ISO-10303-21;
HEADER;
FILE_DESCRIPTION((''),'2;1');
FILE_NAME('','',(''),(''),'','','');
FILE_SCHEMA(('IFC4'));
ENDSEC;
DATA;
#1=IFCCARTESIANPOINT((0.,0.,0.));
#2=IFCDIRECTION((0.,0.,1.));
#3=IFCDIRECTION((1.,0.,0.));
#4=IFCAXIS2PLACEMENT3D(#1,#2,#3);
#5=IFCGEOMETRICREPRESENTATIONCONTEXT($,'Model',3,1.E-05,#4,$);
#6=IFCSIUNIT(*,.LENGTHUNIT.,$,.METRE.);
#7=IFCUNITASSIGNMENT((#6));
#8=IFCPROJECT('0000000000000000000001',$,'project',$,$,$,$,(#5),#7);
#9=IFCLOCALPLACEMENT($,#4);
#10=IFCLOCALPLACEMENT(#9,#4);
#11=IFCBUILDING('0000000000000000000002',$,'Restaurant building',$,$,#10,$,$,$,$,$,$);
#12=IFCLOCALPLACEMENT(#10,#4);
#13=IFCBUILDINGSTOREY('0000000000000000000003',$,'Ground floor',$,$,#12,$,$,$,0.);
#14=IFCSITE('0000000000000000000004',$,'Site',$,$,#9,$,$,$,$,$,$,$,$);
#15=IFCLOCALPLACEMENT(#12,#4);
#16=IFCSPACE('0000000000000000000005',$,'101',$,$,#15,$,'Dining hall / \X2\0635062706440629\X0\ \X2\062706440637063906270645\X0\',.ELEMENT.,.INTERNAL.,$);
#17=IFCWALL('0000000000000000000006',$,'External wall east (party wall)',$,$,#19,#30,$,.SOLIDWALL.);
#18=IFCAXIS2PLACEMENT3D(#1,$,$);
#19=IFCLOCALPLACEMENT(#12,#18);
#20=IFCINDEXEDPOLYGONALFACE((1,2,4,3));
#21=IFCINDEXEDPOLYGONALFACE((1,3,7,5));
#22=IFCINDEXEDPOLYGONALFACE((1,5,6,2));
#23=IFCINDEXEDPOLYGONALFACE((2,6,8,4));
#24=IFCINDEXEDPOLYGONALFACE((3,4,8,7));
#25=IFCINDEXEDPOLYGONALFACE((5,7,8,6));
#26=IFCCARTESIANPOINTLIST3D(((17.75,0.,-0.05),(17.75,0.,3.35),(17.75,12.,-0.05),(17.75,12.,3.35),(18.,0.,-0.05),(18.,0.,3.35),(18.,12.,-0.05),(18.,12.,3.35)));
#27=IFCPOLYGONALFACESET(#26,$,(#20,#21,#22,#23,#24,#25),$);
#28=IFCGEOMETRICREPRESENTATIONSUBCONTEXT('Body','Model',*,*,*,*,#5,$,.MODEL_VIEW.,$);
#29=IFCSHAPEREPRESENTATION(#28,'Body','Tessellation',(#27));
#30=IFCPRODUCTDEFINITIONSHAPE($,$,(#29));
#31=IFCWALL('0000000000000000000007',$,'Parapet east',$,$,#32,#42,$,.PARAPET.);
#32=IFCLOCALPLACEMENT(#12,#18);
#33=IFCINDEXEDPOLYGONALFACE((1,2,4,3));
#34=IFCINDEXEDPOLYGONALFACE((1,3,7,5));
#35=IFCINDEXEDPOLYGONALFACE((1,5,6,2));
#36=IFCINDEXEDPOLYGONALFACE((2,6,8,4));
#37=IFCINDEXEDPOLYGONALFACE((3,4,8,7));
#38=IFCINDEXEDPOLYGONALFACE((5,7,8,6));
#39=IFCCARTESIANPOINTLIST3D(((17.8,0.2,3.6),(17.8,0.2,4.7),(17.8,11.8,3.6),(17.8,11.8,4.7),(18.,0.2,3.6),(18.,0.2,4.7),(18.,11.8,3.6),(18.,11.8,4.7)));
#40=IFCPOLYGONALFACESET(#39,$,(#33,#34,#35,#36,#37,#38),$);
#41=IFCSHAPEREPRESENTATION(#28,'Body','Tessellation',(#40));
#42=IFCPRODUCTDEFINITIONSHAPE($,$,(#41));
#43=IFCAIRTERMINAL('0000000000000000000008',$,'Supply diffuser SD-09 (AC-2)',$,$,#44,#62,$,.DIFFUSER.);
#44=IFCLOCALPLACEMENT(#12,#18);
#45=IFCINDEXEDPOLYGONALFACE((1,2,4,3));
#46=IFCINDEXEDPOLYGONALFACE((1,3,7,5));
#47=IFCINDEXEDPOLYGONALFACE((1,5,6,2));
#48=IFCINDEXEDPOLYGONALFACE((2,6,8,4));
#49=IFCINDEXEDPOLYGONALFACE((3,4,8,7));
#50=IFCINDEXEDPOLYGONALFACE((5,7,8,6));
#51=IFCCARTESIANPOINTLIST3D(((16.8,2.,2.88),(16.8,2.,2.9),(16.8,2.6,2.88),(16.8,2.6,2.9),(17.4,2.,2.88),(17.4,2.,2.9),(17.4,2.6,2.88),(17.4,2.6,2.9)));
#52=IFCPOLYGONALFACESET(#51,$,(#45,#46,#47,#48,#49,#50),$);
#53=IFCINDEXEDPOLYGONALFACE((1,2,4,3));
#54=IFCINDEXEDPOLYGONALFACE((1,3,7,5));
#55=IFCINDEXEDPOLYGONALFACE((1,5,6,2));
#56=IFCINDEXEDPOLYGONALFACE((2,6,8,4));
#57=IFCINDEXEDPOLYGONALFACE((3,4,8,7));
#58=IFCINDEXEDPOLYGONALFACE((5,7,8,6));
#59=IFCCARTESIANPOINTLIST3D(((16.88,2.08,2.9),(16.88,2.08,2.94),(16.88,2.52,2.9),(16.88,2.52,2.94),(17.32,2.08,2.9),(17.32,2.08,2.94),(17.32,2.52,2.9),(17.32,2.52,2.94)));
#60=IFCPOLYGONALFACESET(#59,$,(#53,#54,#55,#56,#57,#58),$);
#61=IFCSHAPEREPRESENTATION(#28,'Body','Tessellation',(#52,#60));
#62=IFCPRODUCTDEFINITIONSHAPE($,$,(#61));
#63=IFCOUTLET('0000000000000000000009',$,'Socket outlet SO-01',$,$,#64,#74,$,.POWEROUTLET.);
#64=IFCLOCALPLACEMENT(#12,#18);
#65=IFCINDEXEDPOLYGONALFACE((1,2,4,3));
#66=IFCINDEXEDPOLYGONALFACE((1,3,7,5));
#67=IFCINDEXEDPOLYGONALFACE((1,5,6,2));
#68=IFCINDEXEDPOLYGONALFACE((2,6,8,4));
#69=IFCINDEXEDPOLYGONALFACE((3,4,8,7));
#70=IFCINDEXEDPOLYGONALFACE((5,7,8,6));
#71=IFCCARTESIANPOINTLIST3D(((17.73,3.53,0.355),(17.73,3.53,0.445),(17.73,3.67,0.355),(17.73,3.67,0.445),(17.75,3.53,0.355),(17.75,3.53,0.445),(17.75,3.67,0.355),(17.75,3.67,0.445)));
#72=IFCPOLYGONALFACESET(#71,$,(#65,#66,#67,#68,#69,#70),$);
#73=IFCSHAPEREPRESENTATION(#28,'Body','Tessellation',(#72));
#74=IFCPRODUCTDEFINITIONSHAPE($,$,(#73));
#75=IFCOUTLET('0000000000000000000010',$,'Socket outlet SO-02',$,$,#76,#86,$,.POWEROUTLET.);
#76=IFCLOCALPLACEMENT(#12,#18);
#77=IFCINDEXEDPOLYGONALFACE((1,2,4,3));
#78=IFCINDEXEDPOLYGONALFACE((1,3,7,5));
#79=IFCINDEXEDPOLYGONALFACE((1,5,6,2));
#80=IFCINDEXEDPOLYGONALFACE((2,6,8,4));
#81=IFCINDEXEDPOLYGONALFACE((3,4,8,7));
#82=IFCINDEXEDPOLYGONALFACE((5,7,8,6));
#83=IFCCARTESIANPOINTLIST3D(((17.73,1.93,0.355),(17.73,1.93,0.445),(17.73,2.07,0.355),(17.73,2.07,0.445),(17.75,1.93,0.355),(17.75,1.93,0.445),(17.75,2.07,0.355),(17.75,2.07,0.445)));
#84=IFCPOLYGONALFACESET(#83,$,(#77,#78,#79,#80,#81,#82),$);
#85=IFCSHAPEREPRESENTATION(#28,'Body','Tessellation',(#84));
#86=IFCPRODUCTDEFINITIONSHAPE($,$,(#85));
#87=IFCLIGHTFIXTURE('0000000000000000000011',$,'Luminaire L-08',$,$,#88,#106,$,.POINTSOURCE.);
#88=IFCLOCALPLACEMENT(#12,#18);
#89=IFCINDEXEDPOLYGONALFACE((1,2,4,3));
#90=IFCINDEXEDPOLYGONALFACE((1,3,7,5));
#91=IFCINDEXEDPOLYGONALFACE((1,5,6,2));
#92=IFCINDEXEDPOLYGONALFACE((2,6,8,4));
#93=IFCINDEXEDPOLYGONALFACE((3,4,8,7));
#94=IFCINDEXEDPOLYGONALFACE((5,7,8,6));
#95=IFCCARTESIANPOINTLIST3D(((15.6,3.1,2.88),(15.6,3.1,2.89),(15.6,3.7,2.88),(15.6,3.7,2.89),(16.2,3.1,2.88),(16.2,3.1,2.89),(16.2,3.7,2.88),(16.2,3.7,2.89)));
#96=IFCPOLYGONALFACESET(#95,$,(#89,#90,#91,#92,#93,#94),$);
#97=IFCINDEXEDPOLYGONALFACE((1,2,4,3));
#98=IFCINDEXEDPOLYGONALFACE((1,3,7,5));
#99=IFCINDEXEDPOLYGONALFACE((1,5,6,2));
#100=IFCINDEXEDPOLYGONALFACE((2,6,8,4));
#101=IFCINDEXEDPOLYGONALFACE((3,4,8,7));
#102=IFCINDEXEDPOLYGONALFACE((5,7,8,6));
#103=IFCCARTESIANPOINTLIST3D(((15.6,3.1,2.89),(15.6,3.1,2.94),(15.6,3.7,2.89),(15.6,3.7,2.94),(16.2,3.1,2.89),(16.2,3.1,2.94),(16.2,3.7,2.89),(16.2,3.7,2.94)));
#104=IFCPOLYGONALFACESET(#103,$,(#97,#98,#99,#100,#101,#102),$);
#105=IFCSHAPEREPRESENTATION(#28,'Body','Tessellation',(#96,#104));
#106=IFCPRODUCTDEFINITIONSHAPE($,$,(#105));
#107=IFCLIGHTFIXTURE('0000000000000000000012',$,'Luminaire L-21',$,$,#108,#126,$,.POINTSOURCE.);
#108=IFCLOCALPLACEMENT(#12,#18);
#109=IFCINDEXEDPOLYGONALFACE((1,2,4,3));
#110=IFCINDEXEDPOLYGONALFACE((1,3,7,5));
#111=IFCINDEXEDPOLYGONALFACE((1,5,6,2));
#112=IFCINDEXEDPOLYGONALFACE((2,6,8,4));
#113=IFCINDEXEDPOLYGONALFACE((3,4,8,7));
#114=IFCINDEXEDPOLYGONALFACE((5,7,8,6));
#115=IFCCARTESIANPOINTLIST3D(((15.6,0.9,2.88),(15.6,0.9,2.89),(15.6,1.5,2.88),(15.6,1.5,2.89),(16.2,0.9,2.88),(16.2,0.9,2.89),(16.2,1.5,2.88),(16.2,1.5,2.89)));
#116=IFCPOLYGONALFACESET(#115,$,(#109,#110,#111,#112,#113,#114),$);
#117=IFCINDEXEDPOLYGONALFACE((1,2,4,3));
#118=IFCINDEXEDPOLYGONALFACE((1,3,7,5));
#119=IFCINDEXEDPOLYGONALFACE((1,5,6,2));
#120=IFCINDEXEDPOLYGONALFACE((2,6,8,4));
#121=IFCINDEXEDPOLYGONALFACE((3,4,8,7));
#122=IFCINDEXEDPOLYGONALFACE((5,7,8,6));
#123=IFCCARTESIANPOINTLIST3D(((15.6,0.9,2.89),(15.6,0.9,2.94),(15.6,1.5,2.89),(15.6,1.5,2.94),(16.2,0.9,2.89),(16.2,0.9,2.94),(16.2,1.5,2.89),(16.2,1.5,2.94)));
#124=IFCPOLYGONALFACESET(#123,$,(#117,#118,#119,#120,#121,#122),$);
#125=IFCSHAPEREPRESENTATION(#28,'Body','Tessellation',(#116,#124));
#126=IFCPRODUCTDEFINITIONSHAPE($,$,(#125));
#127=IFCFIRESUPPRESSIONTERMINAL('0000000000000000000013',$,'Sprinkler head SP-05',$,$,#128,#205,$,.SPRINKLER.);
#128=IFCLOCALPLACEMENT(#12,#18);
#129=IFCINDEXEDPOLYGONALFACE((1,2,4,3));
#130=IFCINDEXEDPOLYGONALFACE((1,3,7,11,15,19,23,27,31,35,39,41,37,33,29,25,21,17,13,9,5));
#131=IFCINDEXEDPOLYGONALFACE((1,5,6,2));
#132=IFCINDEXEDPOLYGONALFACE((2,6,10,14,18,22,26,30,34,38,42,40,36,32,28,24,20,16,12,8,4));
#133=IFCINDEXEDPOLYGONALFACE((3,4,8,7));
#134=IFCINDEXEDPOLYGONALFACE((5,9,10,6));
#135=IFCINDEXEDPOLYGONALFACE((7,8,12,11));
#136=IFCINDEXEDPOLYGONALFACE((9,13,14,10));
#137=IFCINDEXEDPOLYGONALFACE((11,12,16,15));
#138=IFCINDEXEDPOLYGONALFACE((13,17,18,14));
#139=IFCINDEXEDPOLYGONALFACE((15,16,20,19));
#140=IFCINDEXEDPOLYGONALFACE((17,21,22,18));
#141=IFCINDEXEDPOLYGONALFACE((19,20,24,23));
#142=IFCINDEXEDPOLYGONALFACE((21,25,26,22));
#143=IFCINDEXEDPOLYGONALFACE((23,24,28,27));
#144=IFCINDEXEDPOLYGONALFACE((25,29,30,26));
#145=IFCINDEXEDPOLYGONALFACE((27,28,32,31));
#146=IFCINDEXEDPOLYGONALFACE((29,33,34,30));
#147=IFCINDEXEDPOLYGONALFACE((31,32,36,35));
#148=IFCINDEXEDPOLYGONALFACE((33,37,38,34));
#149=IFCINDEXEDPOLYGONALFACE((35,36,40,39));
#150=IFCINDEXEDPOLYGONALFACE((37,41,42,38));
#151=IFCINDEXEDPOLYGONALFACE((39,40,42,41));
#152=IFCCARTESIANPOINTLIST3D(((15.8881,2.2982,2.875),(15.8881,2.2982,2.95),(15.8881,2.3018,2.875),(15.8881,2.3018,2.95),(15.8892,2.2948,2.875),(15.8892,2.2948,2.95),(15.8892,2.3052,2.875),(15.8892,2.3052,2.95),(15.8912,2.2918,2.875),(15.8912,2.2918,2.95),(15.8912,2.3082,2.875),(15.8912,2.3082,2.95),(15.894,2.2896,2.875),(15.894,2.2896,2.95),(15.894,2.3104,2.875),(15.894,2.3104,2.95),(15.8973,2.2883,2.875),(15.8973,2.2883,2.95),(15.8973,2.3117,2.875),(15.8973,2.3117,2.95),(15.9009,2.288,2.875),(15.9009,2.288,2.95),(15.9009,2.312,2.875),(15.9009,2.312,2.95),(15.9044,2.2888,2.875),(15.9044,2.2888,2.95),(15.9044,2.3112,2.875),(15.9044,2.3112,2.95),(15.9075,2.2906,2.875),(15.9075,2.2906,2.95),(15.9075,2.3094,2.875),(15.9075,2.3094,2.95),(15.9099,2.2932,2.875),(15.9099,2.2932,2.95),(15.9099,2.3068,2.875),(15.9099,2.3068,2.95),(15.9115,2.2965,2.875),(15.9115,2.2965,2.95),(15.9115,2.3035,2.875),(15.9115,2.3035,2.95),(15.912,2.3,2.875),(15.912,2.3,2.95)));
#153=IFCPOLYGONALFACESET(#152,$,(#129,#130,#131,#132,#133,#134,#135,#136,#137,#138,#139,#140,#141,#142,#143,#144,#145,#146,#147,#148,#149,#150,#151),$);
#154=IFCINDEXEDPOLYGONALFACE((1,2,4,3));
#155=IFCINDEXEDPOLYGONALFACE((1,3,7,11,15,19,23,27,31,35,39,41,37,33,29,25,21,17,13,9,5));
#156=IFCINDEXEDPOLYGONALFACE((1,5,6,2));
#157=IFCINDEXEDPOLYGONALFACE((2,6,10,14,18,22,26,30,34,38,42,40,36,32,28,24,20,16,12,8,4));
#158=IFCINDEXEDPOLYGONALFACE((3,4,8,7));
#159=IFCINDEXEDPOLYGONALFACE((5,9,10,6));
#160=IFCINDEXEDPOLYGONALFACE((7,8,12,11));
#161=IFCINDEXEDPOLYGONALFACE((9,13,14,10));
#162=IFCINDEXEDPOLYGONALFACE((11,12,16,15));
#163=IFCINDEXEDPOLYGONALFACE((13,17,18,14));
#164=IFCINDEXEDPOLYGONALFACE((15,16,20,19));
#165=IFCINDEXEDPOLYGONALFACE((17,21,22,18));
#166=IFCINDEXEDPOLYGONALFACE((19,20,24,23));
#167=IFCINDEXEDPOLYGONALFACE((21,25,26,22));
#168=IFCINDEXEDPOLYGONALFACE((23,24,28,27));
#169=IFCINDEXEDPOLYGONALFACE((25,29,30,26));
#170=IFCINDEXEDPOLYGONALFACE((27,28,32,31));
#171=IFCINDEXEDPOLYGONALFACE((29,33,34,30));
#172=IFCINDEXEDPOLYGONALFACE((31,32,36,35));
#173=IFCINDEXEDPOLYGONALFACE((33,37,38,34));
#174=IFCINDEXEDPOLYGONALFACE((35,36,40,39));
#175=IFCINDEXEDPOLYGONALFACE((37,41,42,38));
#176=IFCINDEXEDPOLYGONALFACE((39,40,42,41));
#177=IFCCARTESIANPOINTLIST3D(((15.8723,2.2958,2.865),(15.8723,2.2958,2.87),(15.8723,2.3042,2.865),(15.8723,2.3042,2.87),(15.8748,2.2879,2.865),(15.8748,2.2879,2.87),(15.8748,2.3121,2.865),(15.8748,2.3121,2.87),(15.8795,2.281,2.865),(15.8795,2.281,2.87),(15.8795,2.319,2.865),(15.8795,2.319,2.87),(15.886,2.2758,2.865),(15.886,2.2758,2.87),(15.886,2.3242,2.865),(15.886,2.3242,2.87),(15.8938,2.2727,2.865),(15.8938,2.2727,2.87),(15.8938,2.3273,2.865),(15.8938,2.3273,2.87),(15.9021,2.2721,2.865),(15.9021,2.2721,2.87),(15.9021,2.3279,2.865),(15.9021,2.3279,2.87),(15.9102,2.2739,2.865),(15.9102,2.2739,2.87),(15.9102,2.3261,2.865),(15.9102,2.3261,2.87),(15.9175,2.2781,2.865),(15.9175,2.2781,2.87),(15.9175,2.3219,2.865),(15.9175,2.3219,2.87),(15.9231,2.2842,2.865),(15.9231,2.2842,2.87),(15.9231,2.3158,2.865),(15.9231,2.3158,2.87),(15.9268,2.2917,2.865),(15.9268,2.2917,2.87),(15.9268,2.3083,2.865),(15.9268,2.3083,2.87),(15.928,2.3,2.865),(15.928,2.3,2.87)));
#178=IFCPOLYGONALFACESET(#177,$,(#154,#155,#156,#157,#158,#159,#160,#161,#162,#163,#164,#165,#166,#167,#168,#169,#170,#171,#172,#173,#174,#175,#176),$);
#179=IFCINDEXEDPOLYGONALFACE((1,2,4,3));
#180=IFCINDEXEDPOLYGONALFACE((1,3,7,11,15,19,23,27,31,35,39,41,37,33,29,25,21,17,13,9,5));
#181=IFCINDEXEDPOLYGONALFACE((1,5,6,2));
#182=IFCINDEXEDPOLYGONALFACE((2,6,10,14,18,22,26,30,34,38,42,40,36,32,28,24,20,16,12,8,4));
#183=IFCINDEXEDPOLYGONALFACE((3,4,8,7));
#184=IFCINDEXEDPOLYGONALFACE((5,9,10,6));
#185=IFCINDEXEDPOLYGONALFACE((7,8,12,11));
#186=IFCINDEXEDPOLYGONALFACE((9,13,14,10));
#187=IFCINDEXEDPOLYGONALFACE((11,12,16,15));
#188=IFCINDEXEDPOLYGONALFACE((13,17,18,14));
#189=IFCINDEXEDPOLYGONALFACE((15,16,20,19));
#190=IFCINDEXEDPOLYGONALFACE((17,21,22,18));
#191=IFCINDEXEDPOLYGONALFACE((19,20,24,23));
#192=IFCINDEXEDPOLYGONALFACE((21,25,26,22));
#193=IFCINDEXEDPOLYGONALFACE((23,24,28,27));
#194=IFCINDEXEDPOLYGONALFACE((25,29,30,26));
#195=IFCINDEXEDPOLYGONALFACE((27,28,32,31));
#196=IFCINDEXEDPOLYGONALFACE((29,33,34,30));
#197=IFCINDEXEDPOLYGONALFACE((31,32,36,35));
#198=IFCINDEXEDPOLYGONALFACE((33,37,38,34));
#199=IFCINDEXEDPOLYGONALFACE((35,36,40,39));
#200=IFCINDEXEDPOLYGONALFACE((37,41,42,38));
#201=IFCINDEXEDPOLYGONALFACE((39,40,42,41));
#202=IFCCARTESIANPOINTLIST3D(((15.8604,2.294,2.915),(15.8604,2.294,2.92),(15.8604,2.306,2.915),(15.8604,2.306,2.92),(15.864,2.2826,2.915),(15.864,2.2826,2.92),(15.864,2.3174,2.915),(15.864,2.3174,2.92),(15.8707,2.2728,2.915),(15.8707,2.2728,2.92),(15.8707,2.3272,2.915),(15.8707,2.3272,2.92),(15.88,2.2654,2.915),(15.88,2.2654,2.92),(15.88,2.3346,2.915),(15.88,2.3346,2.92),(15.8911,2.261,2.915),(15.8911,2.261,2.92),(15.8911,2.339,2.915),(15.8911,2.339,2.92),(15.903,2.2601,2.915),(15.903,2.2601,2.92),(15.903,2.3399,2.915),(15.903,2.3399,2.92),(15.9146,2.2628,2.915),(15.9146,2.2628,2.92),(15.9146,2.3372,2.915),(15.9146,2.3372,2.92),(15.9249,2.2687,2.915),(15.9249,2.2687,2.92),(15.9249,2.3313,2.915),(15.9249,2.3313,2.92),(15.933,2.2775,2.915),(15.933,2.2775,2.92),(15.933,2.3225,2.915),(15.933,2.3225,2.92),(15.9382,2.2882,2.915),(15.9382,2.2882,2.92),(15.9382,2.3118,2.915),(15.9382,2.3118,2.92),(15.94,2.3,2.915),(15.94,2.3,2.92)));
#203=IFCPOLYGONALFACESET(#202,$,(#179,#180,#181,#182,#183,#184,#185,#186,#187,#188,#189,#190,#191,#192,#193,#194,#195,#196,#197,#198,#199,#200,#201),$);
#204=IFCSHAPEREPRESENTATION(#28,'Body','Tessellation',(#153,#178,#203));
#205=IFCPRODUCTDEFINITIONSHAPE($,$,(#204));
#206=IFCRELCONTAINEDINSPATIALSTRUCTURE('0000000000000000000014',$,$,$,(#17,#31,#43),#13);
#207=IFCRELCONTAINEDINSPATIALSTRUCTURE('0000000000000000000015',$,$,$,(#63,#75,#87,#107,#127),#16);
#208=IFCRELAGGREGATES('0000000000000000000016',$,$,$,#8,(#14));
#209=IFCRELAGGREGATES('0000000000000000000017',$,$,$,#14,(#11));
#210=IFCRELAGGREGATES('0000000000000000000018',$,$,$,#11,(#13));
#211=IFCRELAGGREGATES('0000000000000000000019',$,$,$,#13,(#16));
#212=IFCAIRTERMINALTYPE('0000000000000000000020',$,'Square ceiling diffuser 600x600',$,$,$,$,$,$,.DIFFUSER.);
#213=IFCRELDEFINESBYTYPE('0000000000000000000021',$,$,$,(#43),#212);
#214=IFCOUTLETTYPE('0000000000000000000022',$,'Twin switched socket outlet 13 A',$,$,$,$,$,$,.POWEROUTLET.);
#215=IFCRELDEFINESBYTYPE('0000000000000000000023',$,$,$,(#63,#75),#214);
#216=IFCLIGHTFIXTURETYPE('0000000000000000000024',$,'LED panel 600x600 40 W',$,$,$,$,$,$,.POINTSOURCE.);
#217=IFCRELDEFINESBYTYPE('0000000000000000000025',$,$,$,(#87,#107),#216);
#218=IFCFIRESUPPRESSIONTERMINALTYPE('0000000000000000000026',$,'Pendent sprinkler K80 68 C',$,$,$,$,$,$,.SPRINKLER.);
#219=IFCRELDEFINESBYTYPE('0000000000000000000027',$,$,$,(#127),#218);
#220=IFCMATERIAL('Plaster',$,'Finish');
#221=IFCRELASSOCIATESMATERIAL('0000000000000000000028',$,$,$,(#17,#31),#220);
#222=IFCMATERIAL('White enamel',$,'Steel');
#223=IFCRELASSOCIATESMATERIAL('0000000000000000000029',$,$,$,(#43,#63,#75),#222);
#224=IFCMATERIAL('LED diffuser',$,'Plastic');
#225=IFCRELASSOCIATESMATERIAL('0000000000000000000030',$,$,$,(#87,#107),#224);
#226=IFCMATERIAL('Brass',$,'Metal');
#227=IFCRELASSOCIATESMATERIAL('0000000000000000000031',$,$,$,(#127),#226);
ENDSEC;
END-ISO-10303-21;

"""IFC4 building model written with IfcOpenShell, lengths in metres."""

from ifc_helpers import new_model, si_unit, frame, origin, origin_with_axes, origin_2d, place, context, subcontext, project, spatial, rectangle, circle, extrude, source, transform, mapped, material, type_object, type_shapes, element, save


model = new_model("IFC4")

# Units and contexts
model_context = context("Model", 3, precision=1e-05, world=origin_with_axes())
body_context = subcontext(model_context, "Body", "Model", "MODEL_VIEW")
ifc_project = project(units=[si_unit("LENGTHUNIT", "METRE")], contexts=[model_context])

# Site, building, storey
site_placement = place(None, origin_with_axes())
site = spatial("IfcSite", under=ifc_project, at=site_placement, Name="Site")
building_placement = place(site_placement, origin_with_axes())
building = spatial("IfcBuilding", under=site, at=building_placement, Name="Restaurant building")
storey_placement = place(building_placement, origin_with_axes())
storey = spatial("IfcBuildingStorey", under=building, at=storey_placement, Name="Ground floor", Elevation=0.0)

# Walls
ifc_material_1 = material(Name="Plaster", Category="Finish")
wall_1_placement = place(storey_placement, frame((17.875, 0.0, 0.0), z_axis=(0.0, 0.0, 1.0), x_axis=(0.0, 1.0, 0.0)))
element("IfcWall", 1, at=wall_1_placement, inside=storey, material=ifc_material_1, Name="External wall east (party wall)", PredefinedType="SOLIDWALL", context=body_context, shape_type="SweptSolid", body=[
    extrude(rectangle(XDim=12.0, YDim=0.25, at=origin_2d()), frame((6.0, 0.0, -0.05)), (0.0, 0.0, 1.0), 3.4),
])
wall_2_placement = place(storey_placement, frame((17.9, 0.2, 0.0), z_axis=(0.0, 0.0, 1.0), x_axis=(0.0, 1.0, 0.0)))
element("IfcWall", 2, at=wall_2_placement, inside=storey, material=ifc_material_1, Name="Parapet east", PredefinedType="PARAPET", context=body_context, shape_type="SweptSolid", body=[
    extrude(rectangle(XDim=11.6, YDim=0.2, at=origin_2d()), frame((5.8, 0.0, 3.6)), (0.0, 0.0, 1.0), 1.1),
])

# Air terminal
ifc_material_2 = material(Name="White enamel", Category="Steel")
air_terminal_type = type_object("IfcAirTerminalType", Name="Square ceiling diffuser 600x600", PredefinedType="DIFFUSER")
shared_shape_1 = source(origin(), body_context, "Body", "SweptSolid", [
    extrude(rectangle(XDim=0.6, YDim=0.6, at=origin_2d()), frame((0.0, 0.0, -0.06)), (0.0, 0.0, 1.0), 0.02),
    extrude(rectangle(XDim=0.44, YDim=0.44, at=origin_2d()), frame((0.0, 0.0, -0.04)), (0.0, 0.0, 1.0), 0.04),
])
type_shapes(air_terminal_type, [shared_shape_1])
air_terminal_placement = place(storey_placement, frame((17.1, 2.3, 2.94)))
element("IfcAirTerminal", 3, at=air_terminal_placement, inside=storey, type_object=air_terminal_type, material=ifc_material_2, Name="Supply diffuser SD-09 (AC-2)", PredefinedType="DIFFUSER", context=body_context, shape_type="MappedRepresentation", body=[
    mapped(shared_shape_1, transform((0.0, 0.0, 0.0))),
])

# Shared definitions
space_placement = place(storey_placement, origin_with_axes())
space = spatial("IfcSpace", under=storey, at=space_placement, Name="101", LongName="Dining hall / صالة الطعام", CompositionType="ELEMENT", PredefinedType="INTERNAL")

# Outlets
outlet_type = type_object("IfcOutletType", Name="Twin switched socket outlet 13 A", PredefinedType="POWEROUTLET")
shared_shape_2 = source(origin(), body_context, "Body", "SweptSolid", [
    extrude(rectangle(XDim=0.14, YDim=0.02, at=origin_2d()), frame((0.0, 0.01, -0.045)), (0.0, 0.0, 1.0), 0.09),
])
type_shapes(outlet_type, [shared_shape_2])
for number, where, z_axis, x_axis, name in (
    (4, (17.75, 3.6, 0.4), (0.0, 0.0, 1.0), (0.0, 1.0, 0.0), "Socket outlet SO-01"),
    (5, (17.75, 2.0, 0.4), (0.0, 0.0, 1.0), (0.0, 1.0, 0.0), "Socket outlet SO-02"),
):
    element("IfcOutlet", number, at=place(storey_placement, frame(where, z_axis=z_axis, x_axis=x_axis)), inside=space, type_object=outlet_type, material=ifc_material_2, Name=name, PredefinedType="POWEROUTLET", context=body_context, shape_type="MappedRepresentation", body=[
        mapped(shared_shape_2, transform((0.0, 0.0, 0.0))),
    ])

# Light fixtures
ifc_material_3 = material(Name="LED diffuser", Category="Plastic")
light_fixture_type = type_object("IfcLightFixtureType", Name="LED panel 600x600 40 W", PredefinedType="POINTSOURCE")
shared_shape_3 = source(origin(), body_context, "Body", "SweptSolid", [
    extrude(rectangle(XDim=0.6, YDim=0.6, at=origin_2d()), frame((0.0, 0.0, -0.06)), (0.0, 0.0, 1.0), 0.01),
    extrude(rectangle(XDim=0.6, YDim=0.6, at=origin_2d()), frame((0.0, 0.0, -0.05)), (0.0, 0.0, 1.0), 0.05),
])
type_shapes(light_fixture_type, [shared_shape_3])
for number, where, name in (
    (6, (15.9, 3.4, 2.94), "Luminaire L-08"),
    (7, (15.9, 1.2, 2.94), "Luminaire L-21"),
):
    element("IfcLightFixture", number, at=place(storey_placement, frame(where)), inside=space, type_object=light_fixture_type, material=ifc_material_3, Name=name, PredefinedType="POINTSOURCE", context=body_context, shape_type="MappedRepresentation", body=[
        mapped(shared_shape_3, transform((0.0, 0.0, 0.0))),
    ])

# Fire suppression terminal
ifc_material_4 = material(Name="Brass", Category="Metal")
fire_suppression_terminal_type = type_object("IfcFireSuppressionTerminalType", Name="Pendent sprinkler K80 68 C", PredefinedType="SPRINKLER")
shared_shape_4 = source(origin(), body_context, "Body", "SweptSolid", [
    extrude(circle(Radius=0.012, at=origin_2d()), frame((0.0, 0.0, -0.075)), (0.0, 0.0, 1.0), 0.075),
    extrude(circle(Radius=0.028, at=origin_2d()), frame((0.0, 0.0, -0.085)), (0.0, 0.0, 1.0), 0.005),
    extrude(circle(Radius=0.04, at=origin_2d()), frame((0.0, 0.0, -0.035)), (0.0, 0.0, 1.0), 0.005),
])
type_shapes(fire_suppression_terminal_type, [shared_shape_4])
fire_suppression_terminal_placement = place(storey_placement, frame((15.9, 2.3, 2.95)))
element("IfcFireSuppressionTerminal", 8, at=fire_suppression_terminal_placement, inside=space, type_object=fire_suppression_terminal_type, material=ifc_material_4, Name="Sprinkler head SP-05", PredefinedType="SPRINKLER", context=body_context, shape_type="MappedRepresentation", body=[
    mapped(shared_shape_4, transform((0.0, 0.0, 0.0))),
])

save(model, "model.ifc")
